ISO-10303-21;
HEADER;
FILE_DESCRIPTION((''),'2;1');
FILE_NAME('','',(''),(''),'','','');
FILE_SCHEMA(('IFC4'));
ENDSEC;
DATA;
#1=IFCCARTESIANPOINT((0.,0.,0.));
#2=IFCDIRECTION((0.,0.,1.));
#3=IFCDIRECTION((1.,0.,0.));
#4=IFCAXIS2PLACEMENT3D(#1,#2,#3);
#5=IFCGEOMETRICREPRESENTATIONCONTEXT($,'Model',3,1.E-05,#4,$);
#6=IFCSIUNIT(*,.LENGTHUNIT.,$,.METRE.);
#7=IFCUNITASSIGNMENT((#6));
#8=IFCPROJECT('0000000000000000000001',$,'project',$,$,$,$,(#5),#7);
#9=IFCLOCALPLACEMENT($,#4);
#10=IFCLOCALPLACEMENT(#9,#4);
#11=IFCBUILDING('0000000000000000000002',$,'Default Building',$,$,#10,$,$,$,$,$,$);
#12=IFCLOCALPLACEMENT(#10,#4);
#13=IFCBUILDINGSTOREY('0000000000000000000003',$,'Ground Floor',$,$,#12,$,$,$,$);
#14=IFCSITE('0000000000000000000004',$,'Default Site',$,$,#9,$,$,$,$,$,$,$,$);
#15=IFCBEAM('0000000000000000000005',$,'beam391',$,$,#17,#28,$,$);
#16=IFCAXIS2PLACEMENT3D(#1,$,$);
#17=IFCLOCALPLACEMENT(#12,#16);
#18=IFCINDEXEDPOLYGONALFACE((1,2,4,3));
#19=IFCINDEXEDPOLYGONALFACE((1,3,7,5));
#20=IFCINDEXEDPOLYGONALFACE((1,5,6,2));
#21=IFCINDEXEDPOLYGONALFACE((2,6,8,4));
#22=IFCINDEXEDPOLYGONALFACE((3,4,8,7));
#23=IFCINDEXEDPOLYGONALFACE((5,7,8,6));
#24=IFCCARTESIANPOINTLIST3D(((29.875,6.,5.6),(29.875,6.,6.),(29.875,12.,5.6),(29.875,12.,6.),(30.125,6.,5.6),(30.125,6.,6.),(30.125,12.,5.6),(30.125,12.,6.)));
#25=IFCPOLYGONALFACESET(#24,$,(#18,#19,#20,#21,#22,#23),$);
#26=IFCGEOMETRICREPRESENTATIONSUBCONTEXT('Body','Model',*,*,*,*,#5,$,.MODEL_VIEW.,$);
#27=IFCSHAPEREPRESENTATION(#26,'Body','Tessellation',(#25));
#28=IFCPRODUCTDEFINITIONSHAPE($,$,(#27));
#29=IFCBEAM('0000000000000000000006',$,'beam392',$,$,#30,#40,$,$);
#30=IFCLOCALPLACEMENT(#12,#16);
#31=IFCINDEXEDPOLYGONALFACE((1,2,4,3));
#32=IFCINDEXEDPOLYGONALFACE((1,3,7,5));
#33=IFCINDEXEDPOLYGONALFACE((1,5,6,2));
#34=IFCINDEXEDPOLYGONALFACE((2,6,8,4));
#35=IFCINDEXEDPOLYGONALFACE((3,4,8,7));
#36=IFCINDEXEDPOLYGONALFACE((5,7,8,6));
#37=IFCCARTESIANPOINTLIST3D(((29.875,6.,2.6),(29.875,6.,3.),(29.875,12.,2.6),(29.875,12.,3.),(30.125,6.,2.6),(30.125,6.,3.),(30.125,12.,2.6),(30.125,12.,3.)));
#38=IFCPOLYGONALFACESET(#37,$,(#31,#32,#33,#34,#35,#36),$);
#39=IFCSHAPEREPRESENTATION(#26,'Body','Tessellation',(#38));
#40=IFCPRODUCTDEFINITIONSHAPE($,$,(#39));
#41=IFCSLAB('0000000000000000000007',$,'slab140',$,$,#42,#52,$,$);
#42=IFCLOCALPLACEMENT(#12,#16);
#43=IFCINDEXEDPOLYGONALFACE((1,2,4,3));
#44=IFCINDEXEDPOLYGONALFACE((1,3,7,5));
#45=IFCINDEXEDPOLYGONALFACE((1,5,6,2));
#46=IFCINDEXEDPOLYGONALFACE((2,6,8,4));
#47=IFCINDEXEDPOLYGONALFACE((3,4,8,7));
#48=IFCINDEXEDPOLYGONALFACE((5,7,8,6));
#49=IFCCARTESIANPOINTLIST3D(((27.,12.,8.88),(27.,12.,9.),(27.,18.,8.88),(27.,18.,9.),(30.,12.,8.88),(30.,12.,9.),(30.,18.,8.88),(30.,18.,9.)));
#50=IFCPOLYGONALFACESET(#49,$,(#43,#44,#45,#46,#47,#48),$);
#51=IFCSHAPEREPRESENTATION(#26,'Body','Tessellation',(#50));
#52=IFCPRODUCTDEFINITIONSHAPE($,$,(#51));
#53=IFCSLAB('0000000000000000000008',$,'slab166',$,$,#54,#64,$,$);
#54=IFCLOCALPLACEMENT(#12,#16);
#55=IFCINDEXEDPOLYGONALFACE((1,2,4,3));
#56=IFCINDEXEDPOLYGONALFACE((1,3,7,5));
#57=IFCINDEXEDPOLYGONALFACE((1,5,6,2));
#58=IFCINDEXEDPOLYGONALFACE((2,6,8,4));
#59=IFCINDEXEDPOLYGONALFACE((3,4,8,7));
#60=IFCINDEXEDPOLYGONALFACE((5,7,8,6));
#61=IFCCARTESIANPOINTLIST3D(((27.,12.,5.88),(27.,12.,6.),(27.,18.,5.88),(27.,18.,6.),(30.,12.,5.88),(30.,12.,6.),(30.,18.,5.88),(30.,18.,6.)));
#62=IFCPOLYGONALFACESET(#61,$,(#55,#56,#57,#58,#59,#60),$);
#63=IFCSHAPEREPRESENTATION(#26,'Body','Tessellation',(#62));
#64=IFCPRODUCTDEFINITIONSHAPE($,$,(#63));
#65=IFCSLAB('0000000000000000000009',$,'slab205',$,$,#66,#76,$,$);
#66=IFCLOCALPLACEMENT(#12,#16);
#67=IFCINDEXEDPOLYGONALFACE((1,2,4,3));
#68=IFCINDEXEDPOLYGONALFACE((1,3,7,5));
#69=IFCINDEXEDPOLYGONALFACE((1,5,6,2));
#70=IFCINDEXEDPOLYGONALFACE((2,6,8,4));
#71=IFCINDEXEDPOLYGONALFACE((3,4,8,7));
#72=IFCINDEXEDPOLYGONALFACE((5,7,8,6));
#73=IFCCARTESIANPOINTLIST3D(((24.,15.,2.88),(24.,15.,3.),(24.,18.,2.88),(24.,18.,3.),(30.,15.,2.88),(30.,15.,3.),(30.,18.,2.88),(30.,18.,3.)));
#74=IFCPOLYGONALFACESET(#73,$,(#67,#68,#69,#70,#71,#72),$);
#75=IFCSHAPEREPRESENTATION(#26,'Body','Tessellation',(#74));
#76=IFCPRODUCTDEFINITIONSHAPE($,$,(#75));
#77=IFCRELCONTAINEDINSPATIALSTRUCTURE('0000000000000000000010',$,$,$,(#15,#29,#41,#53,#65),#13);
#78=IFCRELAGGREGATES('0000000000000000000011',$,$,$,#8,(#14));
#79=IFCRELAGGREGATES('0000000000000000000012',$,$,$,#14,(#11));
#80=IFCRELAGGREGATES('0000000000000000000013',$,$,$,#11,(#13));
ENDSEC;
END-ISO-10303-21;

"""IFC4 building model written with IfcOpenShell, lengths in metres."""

from ifc_helpers import new_model, si_unit, frame, origin_with_axes, place, context, subcontext, project, spatial, indexed_curve, outline, extrude, element, save


model = new_model("IFC4")

# Units and contexts
model_context = context("Model", 3, precision=1e-05, world=origin_with_axes())
body_context = subcontext(model_context, "Body", "Model", "MODEL_VIEW")
ifc_project = project(units=[si_unit("LENGTHUNIT", "METRE")], contexts=[model_context])

# Site, building, storey
site_placement = place(None, origin_with_axes())
site = spatial("IfcSite", under=ifc_project, at=site_placement, Name="Default Site")
building_placement = place(site_placement, origin_with_axes())
building = spatial("IfcBuilding", under=site, at=building_placement, Name="Default Building")
storey_placement = place(building_placement, origin_with_axes())
storey = spatial("IfcBuildingStorey", under=building, at=storey_placement, Name="Ground Floor")

# Beams
for number, where, z_axis, x_axis, name in (
    (1, (29.875, 12.0, 5.6), (0.0, 0.0, 1.0), (0.0, -1.0, 0.0), "beam391"),
    (2, (29.875, 12.0, 2.6), (0.0, 0.0, 1.0), (0.0, -1.0, 0.0), "beam392"),
):
    element("IfcBeam", number, at=place(storey_placement, frame(where, z_axis=z_axis, x_axis=x_axis)), inside=storey, Name=name, context=body_context, shape_type="SweptSolid", body=[
        extrude(outline(indexed_curve([(0.0, 0.0), (0.0, 0.25), (6.0, 0.25), (6.0, 0.0), (0.0, 0.0)], self_intersect=False)), origin_with_axes(), (0.0, 0.0, 1.0), 0.4),
    ])

# Slabs
for number, where, z_axis, x_axis, name in (
    (3, (27.0, 12.0, 8.88), (0.0, 0.0, 1.0), (1.0, 0.0, 0.0), "slab140"),
    (4, (27.0, 12.0, 5.88), (0.0, 0.0, 1.0), (1.0, 0.0, 0.0), "slab166"),
):
    element("IfcSlab", number, at=place(storey_placement, frame(where, z_axis=z_axis, x_axis=x_axis)), inside=storey, Name=name, context=body_context, shape_type="SweptSolid", body=[
        extrude(outline(indexed_curve([(0.0, 0.0), (0.0, 6.0), (3.0, 6.0), (3.0, 0.0), (0.0, 0.0)], self_intersect=False)), origin_with_axes(), (0.0, 0.0, 1.0), 0.12),
    ])
slab_placement = place(storey_placement, frame((24.0, 15.0, 2.88), z_axis=(0.0, 0.0, 1.0), x_axis=(1.0, 0.0, 0.0)))
element("IfcSlab", 5, at=slab_placement, inside=storey, Name="slab205", context=body_context, shape_type="SweptSolid", body=[
    extrude(outline(indexed_curve([(0.0, 0.0), (0.0, 3.0), (6.0, 3.0), (6.0, 0.0), (0.0, 0.0)], self_intersect=False)), origin_with_axes(), (0.0, 0.0, 1.0), 0.12),
])

save(model, "model.ifc")
